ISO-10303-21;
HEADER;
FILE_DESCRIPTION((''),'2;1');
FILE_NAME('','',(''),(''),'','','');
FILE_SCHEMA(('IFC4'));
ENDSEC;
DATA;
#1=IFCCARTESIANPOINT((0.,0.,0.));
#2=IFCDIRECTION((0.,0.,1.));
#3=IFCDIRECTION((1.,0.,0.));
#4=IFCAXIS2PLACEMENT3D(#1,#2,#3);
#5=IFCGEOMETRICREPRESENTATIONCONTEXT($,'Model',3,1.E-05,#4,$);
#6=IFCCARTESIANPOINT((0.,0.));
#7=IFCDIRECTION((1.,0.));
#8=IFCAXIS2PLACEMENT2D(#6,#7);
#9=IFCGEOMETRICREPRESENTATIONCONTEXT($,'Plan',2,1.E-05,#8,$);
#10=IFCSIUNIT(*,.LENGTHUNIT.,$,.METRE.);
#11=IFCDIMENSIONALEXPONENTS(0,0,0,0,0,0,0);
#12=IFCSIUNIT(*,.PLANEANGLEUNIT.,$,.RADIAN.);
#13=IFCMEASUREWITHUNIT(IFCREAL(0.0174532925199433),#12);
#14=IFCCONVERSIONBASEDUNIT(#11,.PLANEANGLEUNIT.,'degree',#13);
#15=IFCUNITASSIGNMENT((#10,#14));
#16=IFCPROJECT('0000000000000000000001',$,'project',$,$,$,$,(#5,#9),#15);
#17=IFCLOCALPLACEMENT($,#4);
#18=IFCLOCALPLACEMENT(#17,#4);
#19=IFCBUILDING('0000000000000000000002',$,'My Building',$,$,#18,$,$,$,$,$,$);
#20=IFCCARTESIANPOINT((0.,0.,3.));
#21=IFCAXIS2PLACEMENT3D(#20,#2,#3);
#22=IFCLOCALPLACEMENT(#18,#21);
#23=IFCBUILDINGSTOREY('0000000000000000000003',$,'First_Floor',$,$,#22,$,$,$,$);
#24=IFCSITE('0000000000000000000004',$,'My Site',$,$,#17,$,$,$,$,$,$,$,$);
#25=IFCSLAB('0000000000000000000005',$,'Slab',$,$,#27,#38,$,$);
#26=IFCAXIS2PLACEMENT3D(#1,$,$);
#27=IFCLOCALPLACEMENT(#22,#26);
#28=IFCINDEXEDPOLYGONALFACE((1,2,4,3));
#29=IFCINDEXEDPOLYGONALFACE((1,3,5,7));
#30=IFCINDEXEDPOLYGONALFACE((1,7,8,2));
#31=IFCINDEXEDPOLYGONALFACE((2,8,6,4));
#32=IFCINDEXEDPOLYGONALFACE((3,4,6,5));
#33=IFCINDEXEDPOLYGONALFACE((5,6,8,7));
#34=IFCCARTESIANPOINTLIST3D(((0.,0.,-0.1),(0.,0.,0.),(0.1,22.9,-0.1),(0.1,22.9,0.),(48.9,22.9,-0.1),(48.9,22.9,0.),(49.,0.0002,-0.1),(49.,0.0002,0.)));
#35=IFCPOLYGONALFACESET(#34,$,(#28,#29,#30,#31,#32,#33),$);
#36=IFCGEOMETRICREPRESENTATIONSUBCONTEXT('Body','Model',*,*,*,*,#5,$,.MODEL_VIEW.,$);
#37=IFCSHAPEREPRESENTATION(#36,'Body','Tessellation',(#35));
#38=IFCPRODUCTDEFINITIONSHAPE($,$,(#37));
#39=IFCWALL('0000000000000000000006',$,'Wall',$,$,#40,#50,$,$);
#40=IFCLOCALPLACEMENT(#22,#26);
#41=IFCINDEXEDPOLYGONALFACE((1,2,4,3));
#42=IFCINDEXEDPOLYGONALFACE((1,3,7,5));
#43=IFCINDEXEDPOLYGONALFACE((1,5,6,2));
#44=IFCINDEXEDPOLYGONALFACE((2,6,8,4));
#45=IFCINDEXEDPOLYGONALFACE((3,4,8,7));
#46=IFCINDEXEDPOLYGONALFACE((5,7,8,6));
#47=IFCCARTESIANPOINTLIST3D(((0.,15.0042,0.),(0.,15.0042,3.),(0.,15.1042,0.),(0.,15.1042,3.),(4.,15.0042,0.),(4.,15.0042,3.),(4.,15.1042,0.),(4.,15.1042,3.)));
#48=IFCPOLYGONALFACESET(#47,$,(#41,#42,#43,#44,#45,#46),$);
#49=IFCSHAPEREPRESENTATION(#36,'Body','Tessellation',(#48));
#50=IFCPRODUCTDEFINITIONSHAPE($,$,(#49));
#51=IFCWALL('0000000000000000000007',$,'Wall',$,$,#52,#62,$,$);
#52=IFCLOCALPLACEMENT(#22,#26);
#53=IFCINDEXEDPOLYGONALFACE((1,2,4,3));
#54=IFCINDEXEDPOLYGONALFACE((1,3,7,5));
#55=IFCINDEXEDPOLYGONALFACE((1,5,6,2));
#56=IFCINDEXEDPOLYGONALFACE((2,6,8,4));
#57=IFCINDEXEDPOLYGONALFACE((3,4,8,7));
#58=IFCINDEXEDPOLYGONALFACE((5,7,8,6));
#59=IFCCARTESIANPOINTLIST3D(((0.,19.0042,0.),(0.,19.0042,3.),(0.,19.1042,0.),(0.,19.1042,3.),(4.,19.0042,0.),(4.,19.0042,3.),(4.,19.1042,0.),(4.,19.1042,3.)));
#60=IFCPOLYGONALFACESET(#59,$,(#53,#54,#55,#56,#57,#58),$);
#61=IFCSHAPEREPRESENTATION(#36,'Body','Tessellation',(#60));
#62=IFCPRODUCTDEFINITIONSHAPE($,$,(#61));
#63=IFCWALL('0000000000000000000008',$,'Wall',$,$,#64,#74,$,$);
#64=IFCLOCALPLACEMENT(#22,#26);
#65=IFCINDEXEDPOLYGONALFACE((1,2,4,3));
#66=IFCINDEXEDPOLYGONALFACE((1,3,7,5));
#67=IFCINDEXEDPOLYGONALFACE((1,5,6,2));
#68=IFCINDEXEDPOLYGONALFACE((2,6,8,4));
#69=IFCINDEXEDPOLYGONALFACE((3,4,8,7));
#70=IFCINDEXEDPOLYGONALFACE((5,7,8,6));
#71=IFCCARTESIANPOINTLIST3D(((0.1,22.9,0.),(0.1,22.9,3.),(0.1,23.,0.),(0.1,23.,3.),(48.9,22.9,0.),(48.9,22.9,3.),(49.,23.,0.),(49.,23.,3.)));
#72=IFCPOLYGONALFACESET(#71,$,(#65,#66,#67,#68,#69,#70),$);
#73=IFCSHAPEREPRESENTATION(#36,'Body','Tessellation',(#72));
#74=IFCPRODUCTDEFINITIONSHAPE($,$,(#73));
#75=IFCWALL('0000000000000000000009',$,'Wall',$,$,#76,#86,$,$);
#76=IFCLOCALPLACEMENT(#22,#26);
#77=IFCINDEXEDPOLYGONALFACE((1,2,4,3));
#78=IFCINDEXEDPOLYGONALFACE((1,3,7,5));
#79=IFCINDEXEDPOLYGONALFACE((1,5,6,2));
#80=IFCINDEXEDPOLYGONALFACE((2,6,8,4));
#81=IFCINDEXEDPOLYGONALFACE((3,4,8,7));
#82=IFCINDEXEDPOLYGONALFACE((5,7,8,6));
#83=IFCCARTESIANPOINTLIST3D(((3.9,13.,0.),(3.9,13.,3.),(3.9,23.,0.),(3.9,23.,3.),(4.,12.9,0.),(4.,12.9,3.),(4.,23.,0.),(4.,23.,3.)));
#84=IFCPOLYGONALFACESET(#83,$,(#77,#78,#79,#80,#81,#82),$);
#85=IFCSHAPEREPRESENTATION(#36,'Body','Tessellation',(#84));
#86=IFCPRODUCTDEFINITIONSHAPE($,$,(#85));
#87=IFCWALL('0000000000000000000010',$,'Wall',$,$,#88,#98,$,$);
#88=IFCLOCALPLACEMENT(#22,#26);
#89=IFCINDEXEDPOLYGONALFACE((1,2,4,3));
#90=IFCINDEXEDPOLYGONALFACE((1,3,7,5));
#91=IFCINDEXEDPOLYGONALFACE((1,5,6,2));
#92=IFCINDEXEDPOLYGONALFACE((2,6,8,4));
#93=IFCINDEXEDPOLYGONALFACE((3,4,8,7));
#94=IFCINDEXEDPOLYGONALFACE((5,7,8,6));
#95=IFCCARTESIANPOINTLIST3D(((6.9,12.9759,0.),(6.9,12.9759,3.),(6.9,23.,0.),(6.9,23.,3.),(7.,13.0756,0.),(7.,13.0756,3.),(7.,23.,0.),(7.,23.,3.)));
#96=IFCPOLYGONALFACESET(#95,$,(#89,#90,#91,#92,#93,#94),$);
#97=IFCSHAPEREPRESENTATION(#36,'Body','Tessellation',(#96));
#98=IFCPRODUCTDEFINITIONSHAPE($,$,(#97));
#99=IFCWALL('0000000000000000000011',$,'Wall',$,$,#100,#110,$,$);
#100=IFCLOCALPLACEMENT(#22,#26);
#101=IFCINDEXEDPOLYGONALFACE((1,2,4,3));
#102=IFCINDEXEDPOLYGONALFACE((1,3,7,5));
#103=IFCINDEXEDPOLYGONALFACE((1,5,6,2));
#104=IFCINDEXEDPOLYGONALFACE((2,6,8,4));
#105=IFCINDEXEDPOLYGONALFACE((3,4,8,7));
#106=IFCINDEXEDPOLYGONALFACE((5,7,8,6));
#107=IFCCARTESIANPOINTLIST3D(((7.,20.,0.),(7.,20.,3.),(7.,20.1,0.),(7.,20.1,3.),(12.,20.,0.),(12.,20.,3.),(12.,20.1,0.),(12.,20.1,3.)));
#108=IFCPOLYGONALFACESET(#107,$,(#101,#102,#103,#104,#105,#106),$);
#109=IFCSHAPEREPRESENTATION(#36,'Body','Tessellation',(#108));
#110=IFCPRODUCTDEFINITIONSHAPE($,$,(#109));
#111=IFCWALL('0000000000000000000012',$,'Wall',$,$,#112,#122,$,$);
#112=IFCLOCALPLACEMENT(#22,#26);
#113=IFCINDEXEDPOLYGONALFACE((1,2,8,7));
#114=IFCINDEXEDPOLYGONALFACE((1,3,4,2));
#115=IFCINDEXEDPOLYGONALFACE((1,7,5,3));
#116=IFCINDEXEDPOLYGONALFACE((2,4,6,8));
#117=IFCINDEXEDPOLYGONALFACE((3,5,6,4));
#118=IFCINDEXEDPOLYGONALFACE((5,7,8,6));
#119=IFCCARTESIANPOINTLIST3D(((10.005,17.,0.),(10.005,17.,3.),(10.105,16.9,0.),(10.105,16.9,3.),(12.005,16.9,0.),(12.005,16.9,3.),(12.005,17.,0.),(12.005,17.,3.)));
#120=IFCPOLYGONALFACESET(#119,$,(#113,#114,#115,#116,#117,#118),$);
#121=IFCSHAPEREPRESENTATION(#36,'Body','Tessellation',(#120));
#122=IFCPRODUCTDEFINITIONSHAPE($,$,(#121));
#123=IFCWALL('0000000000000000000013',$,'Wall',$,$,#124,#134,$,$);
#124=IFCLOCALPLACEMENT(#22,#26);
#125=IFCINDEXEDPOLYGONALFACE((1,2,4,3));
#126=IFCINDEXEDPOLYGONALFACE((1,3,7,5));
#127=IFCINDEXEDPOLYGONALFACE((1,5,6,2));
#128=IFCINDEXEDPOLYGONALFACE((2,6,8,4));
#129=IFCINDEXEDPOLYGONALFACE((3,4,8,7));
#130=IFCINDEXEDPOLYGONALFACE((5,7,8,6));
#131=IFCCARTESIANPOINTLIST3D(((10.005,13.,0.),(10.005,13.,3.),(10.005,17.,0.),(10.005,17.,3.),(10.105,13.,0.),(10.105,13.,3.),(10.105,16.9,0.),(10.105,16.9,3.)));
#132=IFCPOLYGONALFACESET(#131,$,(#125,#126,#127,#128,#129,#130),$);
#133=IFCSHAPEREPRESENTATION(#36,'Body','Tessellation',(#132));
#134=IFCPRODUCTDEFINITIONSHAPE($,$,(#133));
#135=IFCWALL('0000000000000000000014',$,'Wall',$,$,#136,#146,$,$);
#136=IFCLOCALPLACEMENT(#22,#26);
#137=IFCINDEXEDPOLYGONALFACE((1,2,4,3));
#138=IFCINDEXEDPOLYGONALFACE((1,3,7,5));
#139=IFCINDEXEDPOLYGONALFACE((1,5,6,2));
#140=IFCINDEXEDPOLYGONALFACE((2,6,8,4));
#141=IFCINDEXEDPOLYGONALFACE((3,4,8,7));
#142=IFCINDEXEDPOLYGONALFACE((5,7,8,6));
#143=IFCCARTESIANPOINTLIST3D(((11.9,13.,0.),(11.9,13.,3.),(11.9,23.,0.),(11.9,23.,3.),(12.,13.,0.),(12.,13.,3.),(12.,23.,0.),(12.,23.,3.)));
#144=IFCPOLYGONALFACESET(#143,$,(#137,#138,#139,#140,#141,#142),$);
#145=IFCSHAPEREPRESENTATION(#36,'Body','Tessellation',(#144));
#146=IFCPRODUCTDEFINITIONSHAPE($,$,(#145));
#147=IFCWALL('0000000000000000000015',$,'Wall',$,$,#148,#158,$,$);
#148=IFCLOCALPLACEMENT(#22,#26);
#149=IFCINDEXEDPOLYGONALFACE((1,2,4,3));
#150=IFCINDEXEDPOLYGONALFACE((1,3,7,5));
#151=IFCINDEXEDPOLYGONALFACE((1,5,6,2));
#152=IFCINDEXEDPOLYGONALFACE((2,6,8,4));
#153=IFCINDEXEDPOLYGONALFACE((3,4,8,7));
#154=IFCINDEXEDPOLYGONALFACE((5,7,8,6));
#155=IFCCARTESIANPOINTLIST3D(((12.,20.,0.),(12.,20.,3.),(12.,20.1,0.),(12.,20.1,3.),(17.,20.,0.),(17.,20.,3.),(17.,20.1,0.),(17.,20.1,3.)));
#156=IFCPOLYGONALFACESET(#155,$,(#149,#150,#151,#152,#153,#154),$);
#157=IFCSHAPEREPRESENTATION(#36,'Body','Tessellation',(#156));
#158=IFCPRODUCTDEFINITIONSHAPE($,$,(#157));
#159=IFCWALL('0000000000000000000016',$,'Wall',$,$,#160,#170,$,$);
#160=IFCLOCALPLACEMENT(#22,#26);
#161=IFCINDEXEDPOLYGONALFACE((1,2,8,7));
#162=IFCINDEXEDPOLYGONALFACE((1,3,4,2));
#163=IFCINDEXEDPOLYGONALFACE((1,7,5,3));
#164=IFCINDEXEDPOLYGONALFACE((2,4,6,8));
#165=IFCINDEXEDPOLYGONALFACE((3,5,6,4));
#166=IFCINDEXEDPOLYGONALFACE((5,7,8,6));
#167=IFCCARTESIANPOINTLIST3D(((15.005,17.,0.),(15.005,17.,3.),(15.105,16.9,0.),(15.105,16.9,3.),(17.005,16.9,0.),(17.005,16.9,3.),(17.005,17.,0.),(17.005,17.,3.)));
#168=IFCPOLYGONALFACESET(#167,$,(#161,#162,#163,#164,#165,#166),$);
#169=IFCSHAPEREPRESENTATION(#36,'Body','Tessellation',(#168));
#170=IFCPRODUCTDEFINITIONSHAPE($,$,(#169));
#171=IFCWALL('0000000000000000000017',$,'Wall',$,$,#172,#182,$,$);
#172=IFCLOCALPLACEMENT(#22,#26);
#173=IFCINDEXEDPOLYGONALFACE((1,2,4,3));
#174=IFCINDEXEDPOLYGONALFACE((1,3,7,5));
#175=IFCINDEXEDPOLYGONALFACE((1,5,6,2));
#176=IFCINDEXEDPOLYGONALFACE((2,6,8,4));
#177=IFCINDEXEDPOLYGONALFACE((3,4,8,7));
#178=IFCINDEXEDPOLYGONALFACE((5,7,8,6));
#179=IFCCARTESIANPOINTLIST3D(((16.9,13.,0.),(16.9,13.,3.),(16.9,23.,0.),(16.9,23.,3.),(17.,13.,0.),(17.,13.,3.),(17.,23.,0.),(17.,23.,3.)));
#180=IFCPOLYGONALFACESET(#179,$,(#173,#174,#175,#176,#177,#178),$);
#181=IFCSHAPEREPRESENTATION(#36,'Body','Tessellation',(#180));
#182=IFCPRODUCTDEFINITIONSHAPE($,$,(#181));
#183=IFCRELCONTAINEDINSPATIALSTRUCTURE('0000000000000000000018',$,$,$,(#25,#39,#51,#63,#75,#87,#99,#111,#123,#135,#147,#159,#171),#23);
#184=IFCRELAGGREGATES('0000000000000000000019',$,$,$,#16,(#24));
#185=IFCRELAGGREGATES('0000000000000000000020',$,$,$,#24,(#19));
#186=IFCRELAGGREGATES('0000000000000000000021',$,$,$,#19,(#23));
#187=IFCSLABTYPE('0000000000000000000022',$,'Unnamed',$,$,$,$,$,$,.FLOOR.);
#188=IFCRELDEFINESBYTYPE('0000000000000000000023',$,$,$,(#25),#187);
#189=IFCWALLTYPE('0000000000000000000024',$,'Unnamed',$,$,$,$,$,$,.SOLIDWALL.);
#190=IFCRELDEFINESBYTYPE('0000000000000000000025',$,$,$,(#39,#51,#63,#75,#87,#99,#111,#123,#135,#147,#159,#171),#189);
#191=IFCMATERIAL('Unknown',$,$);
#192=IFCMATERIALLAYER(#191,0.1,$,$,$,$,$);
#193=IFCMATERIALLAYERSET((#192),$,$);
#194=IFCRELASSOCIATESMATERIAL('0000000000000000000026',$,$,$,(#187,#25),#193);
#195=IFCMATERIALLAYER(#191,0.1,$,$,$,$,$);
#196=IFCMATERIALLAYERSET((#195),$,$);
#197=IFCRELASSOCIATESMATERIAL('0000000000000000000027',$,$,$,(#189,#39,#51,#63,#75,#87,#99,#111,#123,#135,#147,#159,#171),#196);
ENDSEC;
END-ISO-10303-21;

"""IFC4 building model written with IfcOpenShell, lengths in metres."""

from ifc_helpers import new_model, entity, si_unit, converted_unit, frame, origin_with_axes, origin_2d_with_axis, place, context, subcontext, project, spatial, line, indexed_curve, outline, extrude, material, layer, layer_set, layer_usage, type_object, element, save


model = new_model("IFC4")

# Units and contexts
model_context = context("Model", 3, precision=1e-05, world=origin_with_axes())
plan_context = context("Plan", 2, precision=1e-05, world=origin_2d_with_axis())
body_context = subcontext(model_context, "Body", "Model", "MODEL_VIEW")
ifc_project = project(units=[si_unit("LENGTHUNIT", "METRE"), converted_unit("PLANEANGLEUNIT", "degree", entity("IfcReal", 0.0174532925199433), si_unit("PLANEANGLEUNIT", "RADIAN"), dimensions=[0, 0, 0, 0, 0, 0, 0])], contexts=[model_context, plan_context])

# Site, building, storey
site_placement = place(None, origin_with_axes())
site = spatial("IfcSite", under=ifc_project, at=site_placement, Name="My Site")
building_placement = place(site_placement, origin_with_axes())
building = spatial("IfcBuilding", under=site, at=building_placement, Name="My Building")
storey_placement = place(building_placement, frame((0.0, 0.0, 3.0), z_axis=(0.0, 0.0, 1.0), x_axis=(1.0, 0.0, 0.0)))
storey = spatial("IfcBuildingStorey", under=building, at=storey_placement, Name="First_Floor")

# Slab
ifc_material = material(Name="Unknown")
ifc_layer_1 = layer(ifc_material, 0.1)
ifc_layer_set_1 = layer_set([ifc_layer_1])
ifc_layer_usage_1 = layer_usage(ifc_layer_set_1, "AXIS3", "POSITIVE", -0.1)
slab_type = type_object("IfcSlabType", Name="Unnamed", PredefinedType="FLOOR", material=ifc_layer_set_1)
slab_placement = place(storey_placement, frame((0.1, 22.9, 0.0), z_axis=(0.0, 0.0, 1.0), x_axis=(1.0, 0.0, 0.0)))
element("IfcSlab", 1, at=slab_placement, inside=storey, type_object=slab_type, material=ifc_layer_usage_1, Name="Slab", context=body_context, shape_type="SweptSolid", body=[
    extrude(outline(indexed_curve([(0.0, 0.0), (48.8, 0.0), (48.9, -22.8998), (-0.1, -22.9), (0.0, 0.0)])), frame((0.0, 0.0, -0.1), z_axis=(0.0, 0.0, 1.0), x_axis=(1.0, 0.0, 0.0)), (0.0, 0.0, 1.0), 0.1),
])

# Walls
ifc_layer_2 = layer(ifc_material, 0.1)
ifc_layer_set_2 = layer_set([ifc_layer_2])
ifc_layer_usage_2 = layer_usage(ifc_layer_set_2, "AXIS2", "POSITIVE", 0.0)
wall_type = type_object("IfcWallType", Name="Unnamed", PredefinedType="SOLIDWALL", material=ifc_layer_set_2)
wall_1_placement = place(storey_placement, frame((0.0, 15.0042, 0.0), z_axis=(0.0, 0.0, 1.0), x_axis=(1.0, 0.0, 0.0)))
element("IfcWall", 2, at=wall_1_placement, inside=storey, type_object=wall_type, material=ifc_layer_usage_2, Name="Wall", context=body_context, shape_type="SweptSolid", body=[
    extrude(outline(indexed_curve([(0.0, 0.0), (0.0, 0.1), (4.0, 0.1), (4.0, 0.0)], segments=[line(1, 2, 3, 4, 1)])), origin_with_axes(), (0.0, 0.0, 1.0), 3.0),
])
ifc_layer_usage_3 = layer_usage(ifc_layer_set_2, "AXIS2", "POSITIVE", 0.0)
wall_2_placement = place(storey_placement, frame((0.0, 19.0042, 0.0), z_axis=(0.0, 0.0, 1.0), x_axis=(1.0, 0.0, 0.0)))
element("IfcWall", 3, at=wall_2_placement, inside=storey, type_object=wall_type, material=ifc_layer_usage_3, Name="Wall", context=body_context, shape_type="SweptSolid", body=[
    extrude(outline(indexed_curve([(0.0, 0.0), (0.0, 0.1), (4.0, 0.1), (4.0, 0.0)], segments=[line(1, 2, 3, 4, 1)])), origin_with_axes(), (0.0, 0.0, 1.0), 3.0),
])
ifc_layer_usage_4 = layer_usage(ifc_layer_set_2, "AXIS2", "POSITIVE", 0.0)
wall_3_placement = place(storey_placement, frame((0.1, 22.9, 0.0), z_axis=(0.0, 0.0, 1.0), x_axis=(1.0, 0.0, 0.0)))
element("IfcWall", 4, at=wall_3_placement, inside=storey, type_object=wall_type, material=ifc_layer_usage_4, Name="Wall", context=body_context, shape_type="SweptSolid", body=[
    extrude(outline(indexed_curve([(0.0, 0.0), (0.0, 0.1), (48.9, 0.1), (48.8, 0.0)], segments=[line(1, 2, 3, 4, 1)])), origin_with_axes(), (0.0, 0.0, 1.0), 3.0),
])
ifc_layer_usage_5 = layer_usage(ifc_layer_set_2, "AXIS2", "POSITIVE", 0.0)
wall_4_placement = place(storey_placement, frame((3.9, 23.0, 0.0), z_axis=(0.0, 0.0, 1.0), x_axis=(0.0, -1.0, 0.0)))
element("IfcWall", 5, at=wall_4_placement, inside=storey, type_object=wall_type, material=ifc_layer_usage_5, Name="Wall", context=body_context, shape_type="SweptSolid", body=[
    extrude(outline(indexed_curve([(0.0, 0.0), (0.0, 0.1), (10.1, 0.1), (10.0, 0.0)], segments=[line(1, 2, 3, 4, 1)])), origin_with_axes(), (0.0, 0.0, 1.0), 3.0),
])
ifc_layer_usage_6 = layer_usage(ifc_layer_set_2, "AXIS2", "POSITIVE", 0.0)
wall_5_placement = place(storey_placement, frame((6.9, 23.0, 0.0), z_axis=(0.0, 0.0, 1.0), x_axis=(0.0, -1.0, 0.0)))
element("IfcWall", 6, at=wall_5_placement, inside=storey, type_object=wall_type, material=ifc_layer_usage_6, Name="Wall", context=body_context, shape_type="SweptSolid", body=[
    extrude(outline(indexed_curve([(0.0, 0.0), (0.0, 0.1), (9.9244, 0.1), (10.0241, 0.0)], segments=[line(1, 2, 3, 4, 1)])), origin_with_axes(), (0.0, 0.0, 1.0), 3.0),
])
ifc_layer_usage_7 = layer_usage(ifc_layer_set_2, "AXIS2", "POSITIVE", 0.0)
wall_6_placement = place(storey_placement, frame((7.0, 20.0, 0.0), z_axis=(0.0, 0.0, 1.0), x_axis=(1.0, 0.0, 0.0)))
element("IfcWall", 7, at=wall_6_placement, inside=storey, type_object=wall_type, material=ifc_layer_usage_7, Name="Wall", context=body_context, shape_type="SweptSolid", body=[
    extrude(outline(indexed_curve([(0.0, 0.0), (0.0, 0.1), (5.0, 0.1), (5.0, 0.0)], segments=[line(1, 2, 3, 4, 1)])), origin_with_axes(), (0.0, 0.0, 1.0), 3.0),
])
ifc_layer_usage_8 = layer_usage(ifc_layer_set_2, "AXIS2", "POSITIVE", 0.0)
wall_7_placement = place(storey_placement, frame((12.005, 17.0, 0.0), z_axis=(0.0, 0.0, 1.0), x_axis=(-1.0, 0.0, 0.0)))
element("IfcWall", 8, at=wall_7_placement, inside=storey, type_object=wall_type, material=ifc_layer_usage_8, Name="Wall", context=body_context, shape_type="SweptSolid", body=[
    extrude(outline(indexed_curve([(0.0, 0.0), (0.0, 0.1), (1.9, 0.1), (2.0, 0.0)], segments=[line(1, 2, 3, 4, 1)])), origin_with_axes(), (0.0, 0.0, 1.0), 3.0),
])
ifc_layer_usage_9 = layer_usage(ifc_layer_set_2, "AXIS2", "POSITIVE", 0.0)
wall_8_placement = place(storey_placement, frame((10.005, 17.0, 0.0), z_axis=(0.0, 0.0, 1.0), x_axis=(0.0, -1.0, 0.0)))
element("IfcWall", 9, at=wall_8_placement, inside=storey, type_object=wall_type, material=ifc_layer_usage_9, Name="Wall", context=body_context, shape_type="SweptSolid", body=[
    extrude(outline(indexed_curve([(0.0, 0.0), (0.1, 0.1), (4.0, 0.1), (4.0, 0.0)], segments=[line(1, 2, 3, 4, 1)])), origin_with_axes(), (0.0, 0.0, 1.0), 3.0),
])
ifc_layer_usage_10 = layer_usage(ifc_layer_set_2, "AXIS2", "POSITIVE", 0.0)
wall_9_placement = place(storey_placement, frame((11.9, 23.0, 0.0), z_axis=(0.0, 0.0, 1.0), x_axis=(0.0, -1.0, 0.0)))
element("IfcWall", 10, at=wall_9_placement, inside=storey, type_object=wall_type, material=ifc_layer_usage_10, Name="Wall", context=body_context, shape_type="SweptSolid", body=[
    extrude(outline(indexed_curve([(0.0, 0.0), (0.0, 0.1), (10.0, 0.1), (10.0, 0.0)], segments=[line(1, 2, 3, 4, 1)])), origin_with_axes(), (0.0, 0.0, 1.0), 3.0),
])
ifc_layer_usage_11 = layer_usage(ifc_layer_set_2, "AXIS2", "POSITIVE", 0.0)
wall_10_placement = place(storey_placement, frame((12.0, 20.0, 0.0), z_axis=(0.0, 0.0, 1.0), x_axis=(1.0, 0.0, 0.0)))
element("IfcWall", 11, at=wall_10_placement, inside=storey, type_object=wall_type, material=ifc_layer_usage_11, Name="Wall", context=body_context, shape_type="SweptSolid", body=[
    extrude(outline(indexed_curve([(0.0, 0.0), (0.0, 0.1), (5.0, 0.1), (5.0, 0.0)], segments=[line(1, 2, 3, 4, 1)])), origin_with_axes(), (0.0, 0.0, 1.0), 3.0),
])
ifc_layer_usage_12 = layer_usage(ifc_layer_set_2, "AXIS2", "POSITIVE", 0.0)
wall_11_placement = place(storey_placement, frame((17.005, 17.0, 0.0), z_axis=(0.0, 0.0, 1.0), x_axis=(-1.0, 0.0, 0.0)))
element("IfcWall", 12, at=wall_11_placement, inside=storey, type_object=wall_type, material=ifc_layer_usage_12, Name="Wall", context=body_context, shape_type="SweptSolid", body=[
    extrude(outline(indexed_curve([(0.0, 0.0), (0.0, 0.1), (1.9, 0.1), (2.0, 0.0)], segments=[line(1, 2, 3, 4, 1)])), origin_with_axes(), (0.0, 0.0, 1.0), 3.0),
])
ifc_layer_usage_13 = layer_usage(ifc_layer_set_2, "AXIS2", "POSITIVE", 0.0)
wall_12_placement = place(storey_placement, frame((16.9, 23.0, 0.0), z_axis=(0.0, 0.0, 1.0), x_axis=(0.0, -1.0, 0.0)))
element("IfcWall", 13, at=wall_12_placement, inside=storey, type_object=wall_type, material=ifc_layer_usage_13, Name="Wall", context=body_context, shape_type="SweptSolid", body=[
    extrude(outline(indexed_curve([(0.0, 0.0), (0.0, 0.1), (10.0, 0.1), (10.0, 0.0)], segments=[line(1, 2, 3, 4, 1)])), origin_with_axes(), (0.0, 0.0, 1.0), 3.0),
])

save(model, "model.ifc")
